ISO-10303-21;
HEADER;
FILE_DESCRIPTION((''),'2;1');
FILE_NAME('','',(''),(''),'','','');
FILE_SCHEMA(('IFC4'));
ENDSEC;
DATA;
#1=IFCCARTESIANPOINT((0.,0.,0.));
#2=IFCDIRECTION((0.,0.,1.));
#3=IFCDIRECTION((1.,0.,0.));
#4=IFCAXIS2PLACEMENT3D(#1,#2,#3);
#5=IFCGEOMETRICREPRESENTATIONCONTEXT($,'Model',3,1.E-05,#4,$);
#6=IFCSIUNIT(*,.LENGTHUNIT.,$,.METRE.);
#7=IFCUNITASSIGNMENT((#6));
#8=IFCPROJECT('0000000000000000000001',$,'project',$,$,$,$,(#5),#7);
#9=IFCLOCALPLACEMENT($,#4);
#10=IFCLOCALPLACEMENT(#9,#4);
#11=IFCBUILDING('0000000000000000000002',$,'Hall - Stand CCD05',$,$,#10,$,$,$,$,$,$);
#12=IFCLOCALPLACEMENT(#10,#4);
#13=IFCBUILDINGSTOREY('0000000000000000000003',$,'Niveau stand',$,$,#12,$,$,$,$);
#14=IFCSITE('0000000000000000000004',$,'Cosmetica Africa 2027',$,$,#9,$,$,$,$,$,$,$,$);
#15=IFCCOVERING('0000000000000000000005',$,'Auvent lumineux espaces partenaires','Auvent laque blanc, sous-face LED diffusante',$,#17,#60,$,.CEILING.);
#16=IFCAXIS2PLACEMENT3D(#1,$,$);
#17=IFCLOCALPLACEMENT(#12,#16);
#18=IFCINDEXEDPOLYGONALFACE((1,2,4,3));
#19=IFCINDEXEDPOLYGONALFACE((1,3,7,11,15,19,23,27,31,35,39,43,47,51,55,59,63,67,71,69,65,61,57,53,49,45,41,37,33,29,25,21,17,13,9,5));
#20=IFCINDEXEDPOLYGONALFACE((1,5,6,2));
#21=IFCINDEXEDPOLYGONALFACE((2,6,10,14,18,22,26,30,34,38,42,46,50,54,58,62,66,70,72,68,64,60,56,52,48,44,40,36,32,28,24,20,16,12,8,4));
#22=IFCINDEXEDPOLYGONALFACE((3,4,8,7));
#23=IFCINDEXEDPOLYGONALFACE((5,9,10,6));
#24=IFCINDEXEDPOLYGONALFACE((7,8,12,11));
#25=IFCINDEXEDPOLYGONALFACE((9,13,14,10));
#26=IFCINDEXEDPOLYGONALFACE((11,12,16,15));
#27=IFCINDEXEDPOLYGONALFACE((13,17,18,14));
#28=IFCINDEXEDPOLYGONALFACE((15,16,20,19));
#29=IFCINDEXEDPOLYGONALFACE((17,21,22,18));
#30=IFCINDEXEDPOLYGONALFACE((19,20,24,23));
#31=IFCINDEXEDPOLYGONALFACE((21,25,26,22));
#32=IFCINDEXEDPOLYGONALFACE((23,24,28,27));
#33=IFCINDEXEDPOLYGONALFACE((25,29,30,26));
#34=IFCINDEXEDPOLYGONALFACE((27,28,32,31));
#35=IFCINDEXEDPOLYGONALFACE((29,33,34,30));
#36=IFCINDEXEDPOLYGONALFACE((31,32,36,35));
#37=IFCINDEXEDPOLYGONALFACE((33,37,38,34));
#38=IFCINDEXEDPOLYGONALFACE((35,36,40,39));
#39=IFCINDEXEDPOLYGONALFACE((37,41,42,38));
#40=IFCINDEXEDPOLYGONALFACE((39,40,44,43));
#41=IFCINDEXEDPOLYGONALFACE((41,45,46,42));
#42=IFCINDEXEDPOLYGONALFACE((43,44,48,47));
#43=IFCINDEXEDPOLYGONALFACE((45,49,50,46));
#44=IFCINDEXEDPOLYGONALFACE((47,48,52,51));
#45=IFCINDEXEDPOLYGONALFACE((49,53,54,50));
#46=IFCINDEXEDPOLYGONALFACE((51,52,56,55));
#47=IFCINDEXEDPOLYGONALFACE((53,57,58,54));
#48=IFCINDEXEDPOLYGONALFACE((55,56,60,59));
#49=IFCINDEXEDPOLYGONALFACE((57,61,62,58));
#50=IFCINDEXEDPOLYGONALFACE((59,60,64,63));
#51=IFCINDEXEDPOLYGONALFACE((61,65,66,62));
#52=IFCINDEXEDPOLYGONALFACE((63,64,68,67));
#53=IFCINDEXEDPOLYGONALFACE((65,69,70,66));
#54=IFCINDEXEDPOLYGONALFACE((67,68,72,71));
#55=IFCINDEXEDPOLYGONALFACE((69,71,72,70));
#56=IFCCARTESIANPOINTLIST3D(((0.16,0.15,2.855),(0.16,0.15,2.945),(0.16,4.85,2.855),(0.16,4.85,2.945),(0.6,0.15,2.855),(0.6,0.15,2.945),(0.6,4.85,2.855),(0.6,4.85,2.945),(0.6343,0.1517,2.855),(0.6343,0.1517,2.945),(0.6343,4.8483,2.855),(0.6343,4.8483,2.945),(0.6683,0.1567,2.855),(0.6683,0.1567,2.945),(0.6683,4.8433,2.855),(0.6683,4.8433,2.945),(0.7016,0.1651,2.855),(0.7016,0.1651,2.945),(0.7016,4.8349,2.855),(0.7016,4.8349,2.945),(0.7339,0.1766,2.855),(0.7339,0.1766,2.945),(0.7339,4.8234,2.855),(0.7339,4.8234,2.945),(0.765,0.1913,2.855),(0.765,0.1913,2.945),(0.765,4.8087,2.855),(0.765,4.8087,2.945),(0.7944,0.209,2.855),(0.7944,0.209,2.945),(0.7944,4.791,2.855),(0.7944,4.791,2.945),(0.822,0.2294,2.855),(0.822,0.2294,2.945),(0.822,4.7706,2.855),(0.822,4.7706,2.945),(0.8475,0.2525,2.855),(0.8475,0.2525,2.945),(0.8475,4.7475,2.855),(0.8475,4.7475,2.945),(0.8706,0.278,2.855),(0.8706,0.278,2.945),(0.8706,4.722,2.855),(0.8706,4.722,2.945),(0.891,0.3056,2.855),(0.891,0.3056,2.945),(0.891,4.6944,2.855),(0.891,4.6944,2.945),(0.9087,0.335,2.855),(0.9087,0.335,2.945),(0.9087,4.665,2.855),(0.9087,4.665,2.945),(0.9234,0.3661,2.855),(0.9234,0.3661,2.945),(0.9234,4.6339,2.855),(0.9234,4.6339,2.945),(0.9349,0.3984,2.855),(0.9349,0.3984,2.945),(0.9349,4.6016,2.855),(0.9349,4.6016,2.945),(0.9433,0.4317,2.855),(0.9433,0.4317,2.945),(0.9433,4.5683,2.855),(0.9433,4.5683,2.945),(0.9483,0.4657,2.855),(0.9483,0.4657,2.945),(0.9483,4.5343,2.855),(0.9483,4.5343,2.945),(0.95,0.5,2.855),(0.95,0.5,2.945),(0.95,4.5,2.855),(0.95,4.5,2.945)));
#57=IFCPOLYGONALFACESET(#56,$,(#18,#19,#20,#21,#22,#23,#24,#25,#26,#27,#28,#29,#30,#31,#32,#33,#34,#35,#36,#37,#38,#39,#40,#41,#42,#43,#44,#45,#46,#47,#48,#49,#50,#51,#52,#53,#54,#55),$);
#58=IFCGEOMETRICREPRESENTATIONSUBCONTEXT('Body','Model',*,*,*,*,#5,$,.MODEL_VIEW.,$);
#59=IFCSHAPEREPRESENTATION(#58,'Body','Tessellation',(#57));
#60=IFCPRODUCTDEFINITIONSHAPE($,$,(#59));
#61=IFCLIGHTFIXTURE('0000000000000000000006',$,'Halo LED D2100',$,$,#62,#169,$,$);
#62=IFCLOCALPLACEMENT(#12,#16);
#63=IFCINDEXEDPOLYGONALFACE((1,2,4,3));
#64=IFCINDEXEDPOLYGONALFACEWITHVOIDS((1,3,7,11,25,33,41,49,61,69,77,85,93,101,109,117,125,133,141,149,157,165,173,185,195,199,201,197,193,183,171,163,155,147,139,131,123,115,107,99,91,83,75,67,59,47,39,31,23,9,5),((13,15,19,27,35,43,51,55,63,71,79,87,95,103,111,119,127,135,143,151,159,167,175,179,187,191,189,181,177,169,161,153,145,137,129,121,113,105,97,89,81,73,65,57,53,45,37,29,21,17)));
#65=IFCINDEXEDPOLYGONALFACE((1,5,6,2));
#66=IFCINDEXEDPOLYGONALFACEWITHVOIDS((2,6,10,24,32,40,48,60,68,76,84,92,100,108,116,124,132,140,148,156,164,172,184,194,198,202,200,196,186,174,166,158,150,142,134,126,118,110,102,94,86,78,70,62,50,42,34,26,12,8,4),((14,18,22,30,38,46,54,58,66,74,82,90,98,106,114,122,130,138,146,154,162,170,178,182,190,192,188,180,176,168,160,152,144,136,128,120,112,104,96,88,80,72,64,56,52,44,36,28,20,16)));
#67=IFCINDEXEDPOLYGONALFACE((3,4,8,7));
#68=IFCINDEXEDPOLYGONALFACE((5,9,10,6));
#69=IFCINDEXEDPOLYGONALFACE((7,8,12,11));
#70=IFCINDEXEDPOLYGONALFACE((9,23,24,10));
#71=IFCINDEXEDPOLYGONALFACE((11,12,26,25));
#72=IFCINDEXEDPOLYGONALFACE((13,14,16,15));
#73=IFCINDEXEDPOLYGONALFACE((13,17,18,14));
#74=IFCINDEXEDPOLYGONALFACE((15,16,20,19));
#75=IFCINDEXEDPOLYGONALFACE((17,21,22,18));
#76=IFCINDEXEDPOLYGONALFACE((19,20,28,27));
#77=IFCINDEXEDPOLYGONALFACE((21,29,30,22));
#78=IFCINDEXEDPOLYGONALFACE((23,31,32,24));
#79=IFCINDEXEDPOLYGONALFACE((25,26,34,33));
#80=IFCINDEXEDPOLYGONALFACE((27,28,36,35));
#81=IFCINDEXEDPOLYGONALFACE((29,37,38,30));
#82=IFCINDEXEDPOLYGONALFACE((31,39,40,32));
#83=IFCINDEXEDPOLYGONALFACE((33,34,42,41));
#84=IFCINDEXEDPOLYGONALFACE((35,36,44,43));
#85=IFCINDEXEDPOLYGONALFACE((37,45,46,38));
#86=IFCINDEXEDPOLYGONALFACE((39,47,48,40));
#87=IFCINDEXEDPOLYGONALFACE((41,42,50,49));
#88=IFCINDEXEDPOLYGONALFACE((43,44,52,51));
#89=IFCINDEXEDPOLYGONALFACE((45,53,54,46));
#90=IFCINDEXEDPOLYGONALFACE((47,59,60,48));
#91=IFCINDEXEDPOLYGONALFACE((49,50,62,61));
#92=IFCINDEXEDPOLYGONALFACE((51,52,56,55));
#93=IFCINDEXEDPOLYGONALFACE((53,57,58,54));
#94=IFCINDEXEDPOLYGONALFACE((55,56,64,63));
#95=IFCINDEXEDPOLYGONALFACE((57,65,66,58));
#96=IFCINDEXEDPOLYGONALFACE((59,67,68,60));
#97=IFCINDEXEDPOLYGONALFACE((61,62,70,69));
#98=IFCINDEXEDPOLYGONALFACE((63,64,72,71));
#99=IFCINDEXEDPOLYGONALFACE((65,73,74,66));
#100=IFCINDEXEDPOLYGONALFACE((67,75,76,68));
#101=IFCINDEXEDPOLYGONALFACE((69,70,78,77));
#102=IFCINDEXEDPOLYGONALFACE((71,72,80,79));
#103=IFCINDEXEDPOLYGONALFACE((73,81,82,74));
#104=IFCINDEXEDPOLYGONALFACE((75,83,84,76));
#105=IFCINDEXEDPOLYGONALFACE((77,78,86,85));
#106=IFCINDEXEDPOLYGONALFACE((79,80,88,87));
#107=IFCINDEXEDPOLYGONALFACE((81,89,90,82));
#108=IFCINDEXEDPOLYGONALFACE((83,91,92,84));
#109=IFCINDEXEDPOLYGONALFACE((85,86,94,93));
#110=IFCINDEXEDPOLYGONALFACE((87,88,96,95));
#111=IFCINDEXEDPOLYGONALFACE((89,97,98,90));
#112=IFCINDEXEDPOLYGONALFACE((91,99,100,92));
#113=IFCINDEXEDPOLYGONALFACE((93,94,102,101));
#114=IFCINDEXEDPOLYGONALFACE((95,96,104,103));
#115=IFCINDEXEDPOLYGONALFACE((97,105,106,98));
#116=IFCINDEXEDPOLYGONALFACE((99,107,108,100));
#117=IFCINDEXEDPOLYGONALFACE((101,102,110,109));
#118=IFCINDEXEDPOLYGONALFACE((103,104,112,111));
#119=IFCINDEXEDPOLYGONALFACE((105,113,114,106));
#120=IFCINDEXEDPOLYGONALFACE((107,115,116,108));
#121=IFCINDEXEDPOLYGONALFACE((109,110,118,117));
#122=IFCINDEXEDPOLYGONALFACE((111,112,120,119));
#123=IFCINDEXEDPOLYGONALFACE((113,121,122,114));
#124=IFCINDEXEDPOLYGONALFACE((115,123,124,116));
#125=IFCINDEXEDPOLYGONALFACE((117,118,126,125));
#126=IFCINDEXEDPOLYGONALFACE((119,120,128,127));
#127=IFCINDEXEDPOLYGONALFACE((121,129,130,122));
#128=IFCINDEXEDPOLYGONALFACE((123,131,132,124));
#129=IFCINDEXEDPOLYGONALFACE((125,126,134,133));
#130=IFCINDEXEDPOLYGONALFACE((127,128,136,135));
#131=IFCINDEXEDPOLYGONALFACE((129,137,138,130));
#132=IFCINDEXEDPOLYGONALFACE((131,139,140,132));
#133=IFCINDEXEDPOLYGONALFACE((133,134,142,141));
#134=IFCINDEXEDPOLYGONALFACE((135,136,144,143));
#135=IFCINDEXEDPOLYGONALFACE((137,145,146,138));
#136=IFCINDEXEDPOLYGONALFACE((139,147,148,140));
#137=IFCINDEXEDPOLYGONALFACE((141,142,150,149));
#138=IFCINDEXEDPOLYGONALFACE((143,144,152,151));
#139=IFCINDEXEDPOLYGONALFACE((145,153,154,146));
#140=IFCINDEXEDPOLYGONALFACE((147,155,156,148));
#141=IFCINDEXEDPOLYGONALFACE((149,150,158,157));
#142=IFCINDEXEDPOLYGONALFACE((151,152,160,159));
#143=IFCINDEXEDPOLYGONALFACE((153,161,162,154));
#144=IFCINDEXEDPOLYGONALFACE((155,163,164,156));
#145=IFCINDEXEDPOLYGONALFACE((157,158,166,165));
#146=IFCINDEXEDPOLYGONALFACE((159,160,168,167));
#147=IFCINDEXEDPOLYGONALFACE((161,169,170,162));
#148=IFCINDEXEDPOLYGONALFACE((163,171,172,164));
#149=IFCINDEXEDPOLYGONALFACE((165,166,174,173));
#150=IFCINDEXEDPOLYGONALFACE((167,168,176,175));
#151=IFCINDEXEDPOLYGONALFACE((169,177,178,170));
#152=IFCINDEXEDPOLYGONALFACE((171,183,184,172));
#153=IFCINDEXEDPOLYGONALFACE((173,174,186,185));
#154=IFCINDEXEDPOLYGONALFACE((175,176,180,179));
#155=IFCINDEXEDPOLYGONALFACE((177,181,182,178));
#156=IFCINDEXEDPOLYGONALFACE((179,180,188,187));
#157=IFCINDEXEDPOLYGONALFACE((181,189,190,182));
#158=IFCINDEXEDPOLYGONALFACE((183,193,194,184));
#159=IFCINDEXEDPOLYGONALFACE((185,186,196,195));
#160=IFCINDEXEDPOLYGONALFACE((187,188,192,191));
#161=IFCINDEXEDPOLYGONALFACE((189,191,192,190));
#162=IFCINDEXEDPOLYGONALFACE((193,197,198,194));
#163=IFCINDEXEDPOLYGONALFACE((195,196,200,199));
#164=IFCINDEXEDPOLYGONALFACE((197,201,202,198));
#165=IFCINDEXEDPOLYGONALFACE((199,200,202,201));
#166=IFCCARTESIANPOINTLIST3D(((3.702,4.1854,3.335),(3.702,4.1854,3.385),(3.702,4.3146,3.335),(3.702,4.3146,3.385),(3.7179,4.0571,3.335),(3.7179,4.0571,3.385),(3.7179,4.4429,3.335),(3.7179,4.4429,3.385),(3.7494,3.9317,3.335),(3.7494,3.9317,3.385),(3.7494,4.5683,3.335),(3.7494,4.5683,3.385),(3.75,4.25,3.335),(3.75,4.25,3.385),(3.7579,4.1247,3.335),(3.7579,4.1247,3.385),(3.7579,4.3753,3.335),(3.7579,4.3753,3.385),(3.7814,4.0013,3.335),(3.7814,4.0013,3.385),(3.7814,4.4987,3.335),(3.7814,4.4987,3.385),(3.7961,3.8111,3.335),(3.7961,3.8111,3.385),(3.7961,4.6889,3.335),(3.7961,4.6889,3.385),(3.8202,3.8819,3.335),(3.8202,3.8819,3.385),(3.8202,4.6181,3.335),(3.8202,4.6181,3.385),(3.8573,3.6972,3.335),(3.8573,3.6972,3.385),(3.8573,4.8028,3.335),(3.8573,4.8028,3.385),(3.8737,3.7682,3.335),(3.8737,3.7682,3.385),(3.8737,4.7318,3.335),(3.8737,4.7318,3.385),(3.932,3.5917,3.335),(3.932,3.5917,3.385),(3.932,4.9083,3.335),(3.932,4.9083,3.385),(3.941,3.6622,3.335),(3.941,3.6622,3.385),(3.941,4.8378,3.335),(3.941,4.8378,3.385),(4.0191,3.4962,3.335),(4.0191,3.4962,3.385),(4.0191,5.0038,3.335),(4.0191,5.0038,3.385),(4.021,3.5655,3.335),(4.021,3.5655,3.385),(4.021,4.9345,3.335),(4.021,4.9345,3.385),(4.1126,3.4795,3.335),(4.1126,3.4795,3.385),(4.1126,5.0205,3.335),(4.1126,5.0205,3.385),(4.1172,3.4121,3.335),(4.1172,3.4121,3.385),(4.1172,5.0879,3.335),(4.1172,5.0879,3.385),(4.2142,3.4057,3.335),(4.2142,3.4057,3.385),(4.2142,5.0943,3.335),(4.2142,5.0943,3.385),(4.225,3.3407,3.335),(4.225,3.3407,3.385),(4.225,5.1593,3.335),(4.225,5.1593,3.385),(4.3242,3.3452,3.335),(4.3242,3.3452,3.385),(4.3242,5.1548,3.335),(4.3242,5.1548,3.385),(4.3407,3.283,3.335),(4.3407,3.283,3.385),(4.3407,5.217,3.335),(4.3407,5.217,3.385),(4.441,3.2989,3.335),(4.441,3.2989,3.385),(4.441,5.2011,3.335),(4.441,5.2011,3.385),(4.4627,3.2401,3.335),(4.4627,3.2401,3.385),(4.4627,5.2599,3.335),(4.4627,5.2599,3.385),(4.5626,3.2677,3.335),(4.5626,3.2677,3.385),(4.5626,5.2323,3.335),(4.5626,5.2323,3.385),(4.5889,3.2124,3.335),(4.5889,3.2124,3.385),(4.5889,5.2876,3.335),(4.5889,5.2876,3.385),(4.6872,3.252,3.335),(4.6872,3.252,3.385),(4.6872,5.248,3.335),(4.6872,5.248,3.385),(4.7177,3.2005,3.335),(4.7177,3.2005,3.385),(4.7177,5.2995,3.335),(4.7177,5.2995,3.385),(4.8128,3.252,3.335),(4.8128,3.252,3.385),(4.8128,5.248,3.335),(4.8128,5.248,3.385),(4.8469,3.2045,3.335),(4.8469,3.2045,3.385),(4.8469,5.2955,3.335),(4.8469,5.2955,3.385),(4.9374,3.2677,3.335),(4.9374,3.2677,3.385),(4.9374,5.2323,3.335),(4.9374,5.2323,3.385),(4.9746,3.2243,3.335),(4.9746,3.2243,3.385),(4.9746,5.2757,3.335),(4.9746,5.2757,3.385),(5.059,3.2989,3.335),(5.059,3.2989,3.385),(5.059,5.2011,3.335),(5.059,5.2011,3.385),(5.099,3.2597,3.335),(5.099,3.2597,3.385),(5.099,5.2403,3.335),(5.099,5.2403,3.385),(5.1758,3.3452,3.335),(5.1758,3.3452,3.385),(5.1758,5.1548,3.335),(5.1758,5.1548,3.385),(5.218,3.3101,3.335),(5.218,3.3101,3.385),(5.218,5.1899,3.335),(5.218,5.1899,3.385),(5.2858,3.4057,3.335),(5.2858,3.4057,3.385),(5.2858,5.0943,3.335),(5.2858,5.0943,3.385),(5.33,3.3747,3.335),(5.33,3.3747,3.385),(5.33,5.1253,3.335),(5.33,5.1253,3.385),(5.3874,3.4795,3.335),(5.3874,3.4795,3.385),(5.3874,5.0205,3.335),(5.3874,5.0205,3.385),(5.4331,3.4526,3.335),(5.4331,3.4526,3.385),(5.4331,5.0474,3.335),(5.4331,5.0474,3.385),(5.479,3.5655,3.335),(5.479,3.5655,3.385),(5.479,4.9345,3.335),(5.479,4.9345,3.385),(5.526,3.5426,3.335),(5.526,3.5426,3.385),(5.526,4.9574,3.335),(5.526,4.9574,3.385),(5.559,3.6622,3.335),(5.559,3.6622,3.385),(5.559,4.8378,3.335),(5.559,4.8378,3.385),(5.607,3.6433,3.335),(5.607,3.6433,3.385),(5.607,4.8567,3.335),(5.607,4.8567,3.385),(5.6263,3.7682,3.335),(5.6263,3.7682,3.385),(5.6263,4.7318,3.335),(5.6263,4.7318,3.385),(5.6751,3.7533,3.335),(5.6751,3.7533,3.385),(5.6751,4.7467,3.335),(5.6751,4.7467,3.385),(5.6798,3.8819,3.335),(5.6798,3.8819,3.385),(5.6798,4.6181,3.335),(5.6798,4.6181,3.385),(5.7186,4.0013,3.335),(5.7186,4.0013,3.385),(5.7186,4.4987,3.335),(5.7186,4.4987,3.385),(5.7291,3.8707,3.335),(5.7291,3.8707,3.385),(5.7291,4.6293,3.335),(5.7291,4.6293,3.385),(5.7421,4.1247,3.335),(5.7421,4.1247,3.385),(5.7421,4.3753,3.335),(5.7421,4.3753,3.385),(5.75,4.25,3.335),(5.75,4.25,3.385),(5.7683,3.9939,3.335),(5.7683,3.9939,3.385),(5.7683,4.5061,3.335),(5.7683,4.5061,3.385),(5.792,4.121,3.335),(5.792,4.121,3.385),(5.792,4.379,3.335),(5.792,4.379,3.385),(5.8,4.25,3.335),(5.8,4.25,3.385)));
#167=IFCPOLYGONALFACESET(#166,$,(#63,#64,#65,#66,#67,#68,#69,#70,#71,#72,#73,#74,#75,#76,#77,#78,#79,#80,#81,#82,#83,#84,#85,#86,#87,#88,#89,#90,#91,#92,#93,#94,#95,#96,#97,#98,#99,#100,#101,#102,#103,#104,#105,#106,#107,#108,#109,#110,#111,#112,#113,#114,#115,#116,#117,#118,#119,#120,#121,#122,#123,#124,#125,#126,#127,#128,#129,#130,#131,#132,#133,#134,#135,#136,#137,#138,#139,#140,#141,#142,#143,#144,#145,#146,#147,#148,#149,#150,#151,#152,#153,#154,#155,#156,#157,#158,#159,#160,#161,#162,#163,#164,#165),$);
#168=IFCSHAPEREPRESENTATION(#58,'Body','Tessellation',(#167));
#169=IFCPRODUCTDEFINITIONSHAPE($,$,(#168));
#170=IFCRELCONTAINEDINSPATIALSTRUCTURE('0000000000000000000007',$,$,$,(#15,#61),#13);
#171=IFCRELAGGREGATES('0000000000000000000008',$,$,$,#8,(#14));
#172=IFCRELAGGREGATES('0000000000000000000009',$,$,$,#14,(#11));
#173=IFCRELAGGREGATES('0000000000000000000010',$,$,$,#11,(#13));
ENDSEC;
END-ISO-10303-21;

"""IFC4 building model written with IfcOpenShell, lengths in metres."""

from ifc_helpers import new_model, si_unit, frame, frame_2d, origin_with_axes, place, context, subcontext, project, spatial, polyline, hollow_circle, outline, extrude, element, save


model = new_model("IFC4")

# Units and contexts
model_context = context("Model", 3, precision=1e-05, world=origin_with_axes())
body_context = subcontext(model_context, "Body", "Model", "MODEL_VIEW")
ifc_project = project(units=[si_unit("LENGTHUNIT", "METRE")], contexts=[model_context])

# Site, building, storey
site_placement = place(None, origin_with_axes())
site = spatial("IfcSite", under=ifc_project, at=site_placement, Name="Cosmetica Africa 2027")
building_placement = place(site_placement, origin_with_axes())
building = spatial("IfcBuilding", under=site, at=building_placement, Name="Hall - Stand CCD05")
storey_placement = place(building_placement, origin_with_axes())
storey = spatial("IfcBuildingStorey", under=building, at=storey_placement, Name="Niveau stand")

# Covering
covering_1_placement = place(storey_placement, origin_with_axes())
element("IfcCovering", 1, at=covering_1_placement, inside=storey, Name="Auvent lumineux espaces partenaires", Description="Auvent laque blanc, sous-face LED diffusante", PredefinedType="CEILING", context=body_context, shape_type="SweptSolid", body=[
    extrude(outline(polyline([(0.16, 0.15), (0.6, 0.15), (0.6343, 0.1517), (0.6683, 0.1567), (0.7016, 0.1651), (0.7339, 0.1766), (0.765, 0.1913), (0.7944, 0.209), (0.822, 0.2294), (0.8475, 0.2525), (0.8706, 0.278), (0.891, 0.3056), (0.9087, 0.335), (0.9234, 0.3661), (0.9349, 0.3984), (0.9433, 0.4317), (0.9483, 0.4657), (0.95, 0.5), (0.95, 4.5), (0.9483, 4.5343), (0.9433, 4.5683), (0.9349, 4.6016), (0.9234, 4.6339), (0.9087, 4.665), (0.891, 4.6944), (0.8706, 4.722), (0.8475, 4.7475), (0.822, 4.7706), (0.7944, 4.791), (0.765, 4.8087), (0.7339, 4.8234), (0.7016, 4.8349), (0.6683, 4.8433), (0.6343, 4.8483), (0.6, 4.85), (0.16, 4.85), (0.16, 0.15)])), frame((0.0, 0.0, 2.855)), (0.0, 0.0, 1.0), 0.09),
])

# Light fixture
light_fixture_1_placement = place(storey_placement, origin_with_axes())
element("IfcLightFixture", 2, at=light_fixture_1_placement, inside=storey, Name="Halo LED D2100", context=body_context, shape_type="SweptSolid", body=[
    extrude(hollow_circle(Radius=1.05, WallThickness=0.05, at=frame_2d((4.75, 4.25))), frame((0.0, 0.0, 3.335)), (0.0, 0.0, 1.0), 0.05),
])

save(model, "model.ifc")
